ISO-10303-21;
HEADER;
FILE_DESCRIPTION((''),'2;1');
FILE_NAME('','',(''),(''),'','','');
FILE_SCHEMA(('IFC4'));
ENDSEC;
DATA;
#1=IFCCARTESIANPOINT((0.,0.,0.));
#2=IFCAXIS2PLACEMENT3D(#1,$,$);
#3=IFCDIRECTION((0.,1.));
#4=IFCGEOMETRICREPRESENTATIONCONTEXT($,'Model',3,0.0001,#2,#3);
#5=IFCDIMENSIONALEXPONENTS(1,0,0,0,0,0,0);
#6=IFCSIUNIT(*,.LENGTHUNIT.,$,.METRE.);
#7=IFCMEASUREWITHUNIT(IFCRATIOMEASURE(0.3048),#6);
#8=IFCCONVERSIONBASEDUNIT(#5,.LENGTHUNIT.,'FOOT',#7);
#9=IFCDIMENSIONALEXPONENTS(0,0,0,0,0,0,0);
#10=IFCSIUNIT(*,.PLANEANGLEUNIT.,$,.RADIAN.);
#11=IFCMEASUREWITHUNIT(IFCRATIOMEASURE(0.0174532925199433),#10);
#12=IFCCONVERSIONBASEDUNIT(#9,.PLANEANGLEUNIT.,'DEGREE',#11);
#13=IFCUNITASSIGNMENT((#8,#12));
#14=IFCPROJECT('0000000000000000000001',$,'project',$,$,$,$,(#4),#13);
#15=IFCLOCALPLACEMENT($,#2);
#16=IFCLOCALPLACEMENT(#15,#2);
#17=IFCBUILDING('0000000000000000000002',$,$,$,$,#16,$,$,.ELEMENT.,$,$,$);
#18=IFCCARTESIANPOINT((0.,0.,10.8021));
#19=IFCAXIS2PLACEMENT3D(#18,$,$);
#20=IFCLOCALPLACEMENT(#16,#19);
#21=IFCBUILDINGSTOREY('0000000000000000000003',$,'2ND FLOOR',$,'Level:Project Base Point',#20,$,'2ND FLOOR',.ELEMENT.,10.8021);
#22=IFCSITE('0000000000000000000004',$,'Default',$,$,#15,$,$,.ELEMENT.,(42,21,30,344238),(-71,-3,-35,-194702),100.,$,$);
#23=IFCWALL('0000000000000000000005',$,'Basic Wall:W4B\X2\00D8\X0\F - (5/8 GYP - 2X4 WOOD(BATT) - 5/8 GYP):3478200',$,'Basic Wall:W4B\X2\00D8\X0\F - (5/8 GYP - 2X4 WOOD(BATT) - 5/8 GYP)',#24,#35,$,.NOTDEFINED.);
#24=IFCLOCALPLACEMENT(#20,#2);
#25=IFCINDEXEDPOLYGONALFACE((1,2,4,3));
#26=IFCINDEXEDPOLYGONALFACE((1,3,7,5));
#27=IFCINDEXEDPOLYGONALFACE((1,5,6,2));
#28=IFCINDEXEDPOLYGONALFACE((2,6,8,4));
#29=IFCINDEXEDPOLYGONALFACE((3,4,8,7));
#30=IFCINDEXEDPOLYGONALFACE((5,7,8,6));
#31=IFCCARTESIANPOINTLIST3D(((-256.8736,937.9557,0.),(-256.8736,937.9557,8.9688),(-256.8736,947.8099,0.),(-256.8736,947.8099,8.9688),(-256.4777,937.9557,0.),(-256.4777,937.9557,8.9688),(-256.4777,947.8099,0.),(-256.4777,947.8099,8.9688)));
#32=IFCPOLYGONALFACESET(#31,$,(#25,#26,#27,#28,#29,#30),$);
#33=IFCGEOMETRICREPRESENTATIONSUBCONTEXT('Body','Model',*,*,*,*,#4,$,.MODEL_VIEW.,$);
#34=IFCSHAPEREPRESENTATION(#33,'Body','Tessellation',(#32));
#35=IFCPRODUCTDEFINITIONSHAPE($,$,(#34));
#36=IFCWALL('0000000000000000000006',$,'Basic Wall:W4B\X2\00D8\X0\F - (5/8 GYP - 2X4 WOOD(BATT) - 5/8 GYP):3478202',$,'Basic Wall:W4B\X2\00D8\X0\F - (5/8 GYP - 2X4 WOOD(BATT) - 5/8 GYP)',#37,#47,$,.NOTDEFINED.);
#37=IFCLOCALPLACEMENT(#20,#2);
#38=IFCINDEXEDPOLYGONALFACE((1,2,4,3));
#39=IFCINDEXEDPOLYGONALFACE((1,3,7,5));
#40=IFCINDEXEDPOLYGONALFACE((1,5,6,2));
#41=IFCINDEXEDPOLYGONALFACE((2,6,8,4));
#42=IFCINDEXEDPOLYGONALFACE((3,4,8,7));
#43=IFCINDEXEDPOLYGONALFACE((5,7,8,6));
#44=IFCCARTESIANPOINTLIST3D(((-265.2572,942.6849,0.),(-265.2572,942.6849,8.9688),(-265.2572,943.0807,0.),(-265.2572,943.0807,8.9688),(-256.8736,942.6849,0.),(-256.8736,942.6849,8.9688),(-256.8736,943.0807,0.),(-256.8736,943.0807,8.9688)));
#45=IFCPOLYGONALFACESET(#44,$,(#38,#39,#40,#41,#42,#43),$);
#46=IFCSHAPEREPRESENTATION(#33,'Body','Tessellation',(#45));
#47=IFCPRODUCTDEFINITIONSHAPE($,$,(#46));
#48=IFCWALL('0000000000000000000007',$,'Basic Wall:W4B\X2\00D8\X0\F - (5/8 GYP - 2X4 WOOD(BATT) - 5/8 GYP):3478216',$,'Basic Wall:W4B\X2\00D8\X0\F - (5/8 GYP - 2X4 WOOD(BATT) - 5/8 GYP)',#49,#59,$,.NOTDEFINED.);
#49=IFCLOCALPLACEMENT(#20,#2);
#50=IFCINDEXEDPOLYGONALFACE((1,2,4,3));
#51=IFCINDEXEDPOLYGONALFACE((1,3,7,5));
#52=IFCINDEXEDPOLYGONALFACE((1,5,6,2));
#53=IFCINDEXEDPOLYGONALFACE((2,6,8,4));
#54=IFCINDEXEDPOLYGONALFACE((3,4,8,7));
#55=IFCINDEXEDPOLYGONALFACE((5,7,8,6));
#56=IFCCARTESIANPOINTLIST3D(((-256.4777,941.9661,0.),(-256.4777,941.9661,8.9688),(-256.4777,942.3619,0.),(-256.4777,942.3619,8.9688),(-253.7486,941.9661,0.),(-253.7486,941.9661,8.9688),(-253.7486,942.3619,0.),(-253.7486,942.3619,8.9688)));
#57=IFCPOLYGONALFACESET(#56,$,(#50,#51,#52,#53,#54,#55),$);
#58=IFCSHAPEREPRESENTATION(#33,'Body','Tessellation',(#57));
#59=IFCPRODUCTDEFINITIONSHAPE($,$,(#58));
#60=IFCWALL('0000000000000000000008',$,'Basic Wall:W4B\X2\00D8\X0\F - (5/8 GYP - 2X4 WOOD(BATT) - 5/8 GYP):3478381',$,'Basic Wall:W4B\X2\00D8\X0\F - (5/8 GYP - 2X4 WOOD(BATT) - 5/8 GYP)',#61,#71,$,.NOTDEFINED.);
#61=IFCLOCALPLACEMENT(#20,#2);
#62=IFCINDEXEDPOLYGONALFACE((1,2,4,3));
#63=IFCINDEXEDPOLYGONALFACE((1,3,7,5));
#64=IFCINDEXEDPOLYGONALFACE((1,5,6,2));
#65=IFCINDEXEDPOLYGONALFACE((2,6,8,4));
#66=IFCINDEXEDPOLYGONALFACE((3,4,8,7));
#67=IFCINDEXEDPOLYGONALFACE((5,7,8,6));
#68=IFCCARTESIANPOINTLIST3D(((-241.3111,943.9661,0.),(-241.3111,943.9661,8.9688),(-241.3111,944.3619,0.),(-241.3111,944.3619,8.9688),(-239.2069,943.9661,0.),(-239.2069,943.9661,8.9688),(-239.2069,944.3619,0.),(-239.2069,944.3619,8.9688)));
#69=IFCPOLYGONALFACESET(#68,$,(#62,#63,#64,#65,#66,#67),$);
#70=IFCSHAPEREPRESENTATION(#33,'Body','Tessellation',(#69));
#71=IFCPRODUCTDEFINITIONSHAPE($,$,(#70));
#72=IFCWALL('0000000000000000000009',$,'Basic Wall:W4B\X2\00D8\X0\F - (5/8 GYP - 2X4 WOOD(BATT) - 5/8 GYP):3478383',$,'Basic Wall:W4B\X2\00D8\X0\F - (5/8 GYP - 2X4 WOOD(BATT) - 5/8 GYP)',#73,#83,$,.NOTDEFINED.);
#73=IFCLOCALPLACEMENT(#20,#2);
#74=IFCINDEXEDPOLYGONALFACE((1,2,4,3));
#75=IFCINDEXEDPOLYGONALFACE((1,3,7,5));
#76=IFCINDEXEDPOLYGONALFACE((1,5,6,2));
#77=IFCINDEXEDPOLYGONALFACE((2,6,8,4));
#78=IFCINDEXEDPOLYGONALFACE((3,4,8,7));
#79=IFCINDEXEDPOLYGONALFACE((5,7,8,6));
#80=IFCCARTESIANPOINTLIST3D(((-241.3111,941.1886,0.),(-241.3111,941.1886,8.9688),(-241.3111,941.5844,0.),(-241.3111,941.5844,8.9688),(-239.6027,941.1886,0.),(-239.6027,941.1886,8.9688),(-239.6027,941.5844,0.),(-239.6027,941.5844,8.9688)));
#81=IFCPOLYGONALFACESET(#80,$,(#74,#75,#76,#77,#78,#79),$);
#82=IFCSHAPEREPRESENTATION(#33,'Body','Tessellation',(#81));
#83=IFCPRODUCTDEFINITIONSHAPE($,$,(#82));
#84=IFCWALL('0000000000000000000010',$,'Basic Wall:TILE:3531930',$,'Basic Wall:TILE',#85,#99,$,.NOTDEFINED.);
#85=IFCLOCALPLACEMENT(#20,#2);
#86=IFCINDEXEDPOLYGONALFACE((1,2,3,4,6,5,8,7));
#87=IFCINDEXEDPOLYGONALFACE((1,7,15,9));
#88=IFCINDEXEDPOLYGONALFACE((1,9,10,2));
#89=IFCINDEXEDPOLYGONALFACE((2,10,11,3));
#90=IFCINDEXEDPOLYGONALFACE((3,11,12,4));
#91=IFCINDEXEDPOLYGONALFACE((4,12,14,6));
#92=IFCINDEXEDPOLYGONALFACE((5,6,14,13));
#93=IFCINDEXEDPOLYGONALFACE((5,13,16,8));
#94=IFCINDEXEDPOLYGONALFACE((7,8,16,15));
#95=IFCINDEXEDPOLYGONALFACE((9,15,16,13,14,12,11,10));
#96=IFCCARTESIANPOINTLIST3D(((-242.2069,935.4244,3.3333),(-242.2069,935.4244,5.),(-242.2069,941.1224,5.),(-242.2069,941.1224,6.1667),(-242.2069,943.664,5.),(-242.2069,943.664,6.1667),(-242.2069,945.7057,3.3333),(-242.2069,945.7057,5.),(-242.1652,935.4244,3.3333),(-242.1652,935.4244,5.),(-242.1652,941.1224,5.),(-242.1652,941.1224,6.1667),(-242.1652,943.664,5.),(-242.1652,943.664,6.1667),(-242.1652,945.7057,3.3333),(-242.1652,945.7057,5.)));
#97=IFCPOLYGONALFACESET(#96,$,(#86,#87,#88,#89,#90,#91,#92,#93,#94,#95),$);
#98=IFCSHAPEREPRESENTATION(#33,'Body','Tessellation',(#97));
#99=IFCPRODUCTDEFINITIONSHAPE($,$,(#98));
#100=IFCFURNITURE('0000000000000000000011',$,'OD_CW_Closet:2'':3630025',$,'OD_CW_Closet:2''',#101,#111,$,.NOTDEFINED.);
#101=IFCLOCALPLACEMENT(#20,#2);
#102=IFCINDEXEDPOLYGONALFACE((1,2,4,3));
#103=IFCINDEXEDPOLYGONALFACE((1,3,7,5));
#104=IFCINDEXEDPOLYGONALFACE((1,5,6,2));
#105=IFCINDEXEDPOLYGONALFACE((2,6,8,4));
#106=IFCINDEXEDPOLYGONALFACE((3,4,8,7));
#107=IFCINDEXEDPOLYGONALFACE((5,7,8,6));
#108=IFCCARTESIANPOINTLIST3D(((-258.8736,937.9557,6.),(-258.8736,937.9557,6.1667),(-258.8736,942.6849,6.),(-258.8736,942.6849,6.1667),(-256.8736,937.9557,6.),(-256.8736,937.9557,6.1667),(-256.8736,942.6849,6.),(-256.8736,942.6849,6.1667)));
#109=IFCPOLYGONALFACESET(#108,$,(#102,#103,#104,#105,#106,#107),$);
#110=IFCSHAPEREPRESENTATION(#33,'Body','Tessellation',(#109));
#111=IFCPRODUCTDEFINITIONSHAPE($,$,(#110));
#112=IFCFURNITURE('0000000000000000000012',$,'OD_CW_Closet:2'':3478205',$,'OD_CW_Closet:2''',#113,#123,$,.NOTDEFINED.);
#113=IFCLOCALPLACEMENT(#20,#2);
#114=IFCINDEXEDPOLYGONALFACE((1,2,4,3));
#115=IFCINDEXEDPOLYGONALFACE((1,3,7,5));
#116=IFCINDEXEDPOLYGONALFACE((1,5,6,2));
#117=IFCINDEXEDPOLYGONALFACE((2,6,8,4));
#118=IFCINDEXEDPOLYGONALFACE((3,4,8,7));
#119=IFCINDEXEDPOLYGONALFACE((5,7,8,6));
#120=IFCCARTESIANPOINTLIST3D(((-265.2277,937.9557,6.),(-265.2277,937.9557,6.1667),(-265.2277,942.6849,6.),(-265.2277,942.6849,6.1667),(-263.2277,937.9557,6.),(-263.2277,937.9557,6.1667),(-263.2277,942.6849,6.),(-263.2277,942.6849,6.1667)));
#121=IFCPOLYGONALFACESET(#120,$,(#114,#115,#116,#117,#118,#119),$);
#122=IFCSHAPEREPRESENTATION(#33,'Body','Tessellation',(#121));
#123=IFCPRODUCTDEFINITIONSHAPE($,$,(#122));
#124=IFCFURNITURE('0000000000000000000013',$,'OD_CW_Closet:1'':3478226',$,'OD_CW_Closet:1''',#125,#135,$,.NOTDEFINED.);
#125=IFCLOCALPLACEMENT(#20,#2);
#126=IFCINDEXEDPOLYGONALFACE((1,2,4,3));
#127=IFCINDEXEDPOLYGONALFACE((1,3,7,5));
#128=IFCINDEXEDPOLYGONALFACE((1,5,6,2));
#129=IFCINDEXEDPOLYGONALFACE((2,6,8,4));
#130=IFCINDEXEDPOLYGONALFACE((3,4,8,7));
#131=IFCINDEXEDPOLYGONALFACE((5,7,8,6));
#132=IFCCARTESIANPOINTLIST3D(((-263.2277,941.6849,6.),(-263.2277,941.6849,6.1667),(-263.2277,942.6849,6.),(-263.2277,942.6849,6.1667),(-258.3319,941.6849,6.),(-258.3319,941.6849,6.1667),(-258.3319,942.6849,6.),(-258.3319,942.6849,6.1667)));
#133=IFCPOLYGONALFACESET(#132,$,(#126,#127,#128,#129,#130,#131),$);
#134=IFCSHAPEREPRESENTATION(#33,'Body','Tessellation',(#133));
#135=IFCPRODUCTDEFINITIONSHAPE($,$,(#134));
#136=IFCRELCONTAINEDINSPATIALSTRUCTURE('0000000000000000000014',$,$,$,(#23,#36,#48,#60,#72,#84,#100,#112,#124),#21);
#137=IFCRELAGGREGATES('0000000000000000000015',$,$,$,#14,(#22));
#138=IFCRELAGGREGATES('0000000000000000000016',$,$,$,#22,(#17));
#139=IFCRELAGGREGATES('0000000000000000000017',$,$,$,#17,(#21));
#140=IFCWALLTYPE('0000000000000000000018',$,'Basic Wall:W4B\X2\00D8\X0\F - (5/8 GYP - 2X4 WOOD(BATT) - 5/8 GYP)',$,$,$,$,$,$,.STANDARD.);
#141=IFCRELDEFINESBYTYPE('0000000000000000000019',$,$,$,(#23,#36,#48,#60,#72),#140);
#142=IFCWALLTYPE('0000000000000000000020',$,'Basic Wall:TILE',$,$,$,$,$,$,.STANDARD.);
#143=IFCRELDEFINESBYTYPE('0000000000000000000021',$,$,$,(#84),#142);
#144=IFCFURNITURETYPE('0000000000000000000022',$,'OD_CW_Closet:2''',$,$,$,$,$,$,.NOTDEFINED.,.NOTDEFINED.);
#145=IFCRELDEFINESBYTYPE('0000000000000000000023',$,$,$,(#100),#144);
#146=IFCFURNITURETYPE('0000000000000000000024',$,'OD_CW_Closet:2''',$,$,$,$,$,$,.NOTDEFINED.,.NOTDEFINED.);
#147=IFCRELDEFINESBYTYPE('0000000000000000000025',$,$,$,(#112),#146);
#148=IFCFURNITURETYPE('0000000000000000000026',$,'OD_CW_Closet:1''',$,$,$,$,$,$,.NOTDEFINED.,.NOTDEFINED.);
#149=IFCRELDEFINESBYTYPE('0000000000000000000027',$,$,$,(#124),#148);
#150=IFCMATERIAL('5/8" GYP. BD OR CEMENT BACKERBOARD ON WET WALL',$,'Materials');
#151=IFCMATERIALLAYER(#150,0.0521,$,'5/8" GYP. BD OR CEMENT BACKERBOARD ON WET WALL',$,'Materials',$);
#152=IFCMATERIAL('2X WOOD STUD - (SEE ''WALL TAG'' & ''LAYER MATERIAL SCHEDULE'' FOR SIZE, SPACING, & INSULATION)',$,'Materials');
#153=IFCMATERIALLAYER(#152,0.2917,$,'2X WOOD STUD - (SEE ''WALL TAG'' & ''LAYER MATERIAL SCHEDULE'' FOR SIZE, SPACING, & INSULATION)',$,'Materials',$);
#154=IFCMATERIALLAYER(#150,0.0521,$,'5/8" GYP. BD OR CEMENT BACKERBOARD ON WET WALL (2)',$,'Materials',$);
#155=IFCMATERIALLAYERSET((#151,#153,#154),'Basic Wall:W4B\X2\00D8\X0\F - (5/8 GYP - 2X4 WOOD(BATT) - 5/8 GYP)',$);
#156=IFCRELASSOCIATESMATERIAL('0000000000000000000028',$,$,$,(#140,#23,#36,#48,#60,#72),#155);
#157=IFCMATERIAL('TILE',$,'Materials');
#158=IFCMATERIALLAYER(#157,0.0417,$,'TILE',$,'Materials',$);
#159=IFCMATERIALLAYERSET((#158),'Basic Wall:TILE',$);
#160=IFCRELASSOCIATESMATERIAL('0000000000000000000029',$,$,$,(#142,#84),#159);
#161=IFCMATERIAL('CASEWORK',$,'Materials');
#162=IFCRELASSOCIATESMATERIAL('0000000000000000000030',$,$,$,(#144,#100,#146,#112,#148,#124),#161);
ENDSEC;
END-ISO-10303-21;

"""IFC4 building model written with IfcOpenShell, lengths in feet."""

from ifc_helpers import new_model, entity, si_unit, converted_unit, direction, frame, frame_2d, origin, origin_2d_with_axis, place, context, subcontext, project, spatial, rectangle, extrude, source, transform, mapped, material, layer, layer_set, layer_usage, type_object, type_shapes, element, save


model = new_model("IFC4")

# Units and contexts
model_context = context("Model", 3, precision=0.0001, world=origin(), true_north=direction((0.0, 1.0)))
body_context = subcontext(model_context, "Body", "Model", "MODEL_VIEW")
ifc_project = project(units=[converted_unit("LENGTHUNIT", "FOOT", entity("IfcRatioMeasure", 0.3048), si_unit("LENGTHUNIT", "METRE"), dimensions=[1, 0, 0, 0, 0, 0, 0]), converted_unit("PLANEANGLEUNIT", "DEGREE", entity("IfcRatioMeasure", 0.0174532925199433), si_unit("PLANEANGLEUNIT", "RADIAN"), dimensions=[0, 0, 0, 0, 0, 0, 0])], contexts=[model_context])

# Site, building, storey
site_placement = place(None, origin())
site = spatial("IfcSite", under=ifc_project, at=site_placement, Name="Default", CompositionType="ELEMENT", RefLatitude=(42, 21, 30, 344238), RefLongitude=(-71, -3, -35, -194702), RefElevation=100.0)
building_placement = place(site_placement, origin())
building = spatial("IfcBuilding", under=site, at=building_placement, CompositionType="ELEMENT")
storey_placement = place(building_placement, frame((0.0, 0.0, 10.8021)))
storey = spatial("IfcBuildingStorey", under=building, at=storey_placement, Name="2ND FLOOR", ObjectType="Level:Project Base Point", LongName="2ND FLOOR", CompositionType="ELEMENT", Elevation=10.8021)

# Shared definitions
ifc_material_1 = material(Name="5/8\" GYP. BD OR CEMENT BACKERBOARD ON WET WALL", Category="Materials")
ifc_layer_1 = layer(ifc_material_1, 0.0521, Name="5/8\" GYP. BD OR CEMENT BACKERBOARD ON WET WALL", Category="Materials")
ifc_material_2 = material(Name="2X WOOD STUD - (SEE 'WALL TAG' & 'LAYER MATERIAL SCHEDULE' FOR SIZE, SPACING, & INSULATION)", Category="Materials")
ifc_layer_2 = layer(ifc_material_2, 0.2917, Name="2X WOOD STUD - (SEE 'WALL TAG' & 'LAYER MATERIAL SCHEDULE' FOR SIZE, SPACING, & INSULATION)", Category="Materials")
ifc_layer_3 = layer(ifc_material_1, 0.0521, Name="5/8\" GYP. BD OR CEMENT BACKERBOARD ON WET WALL (2)", Category="Materials")
ifc_layer_set_1 = layer_set([ifc_layer_1, ifc_layer_2, ifc_layer_3], Name="Basic Wall:W4BØF - (5/8 GYP - 2X4 WOOD(BATT) - 5/8 GYP)")
wall_type_1 = type_object("IfcWallType", Name="Basic Wall:W4BØF - (5/8 GYP - 2X4 WOOD(BATT) - 5/8 GYP)", PredefinedType="STANDARD", material=ifc_layer_set_1)

# Walls
ifc_layer_usage_1 = layer_usage(ifc_layer_set_1, "AXIS2", "NEGATIVE", 0.1979)
wall_1_placement = place(storey_placement, frame((-256.6757, 937.9557, 0.0), z_axis=(0.0, 0.0, 1.0), x_axis=(0.0, 1.0, 0.0)))
element("IfcWall", 1, at=wall_1_placement, inside=storey, type_object=wall_type_1, material=ifc_layer_usage_1, Name="Basic Wall:W4BØF - (5/8 GYP - 2X4 WOOD(BATT) - 5/8 GYP):3478200", ObjectType="Basic Wall:W4BØF - (5/8 GYP - 2X4 WOOD(BATT) - 5/8 GYP)", PredefinedType="NOTDEFINED", context=body_context, shape_type="SweptSolid", body=[
    extrude(rectangle(XDim=9.8542, YDim=0.3958, at=frame_2d((4.9271, 0.0), x_axis=(-1.0, 0.0))), origin(), (0.0, 0.0, 1.0), 8.9688),
])
ifc_layer_usage_2 = layer_usage(ifc_layer_set_1, "AXIS2", "POSITIVE", -0.1979)
wall_2_placement = place(storey_placement, frame((-256.8736, 942.8828, 0.0), z_axis=(0.0, 0.0, 1.0), x_axis=(-1.0, 0.0, 0.0)))
element("IfcWall", 2, at=wall_2_placement, inside=storey, type_object=wall_type_1, material=ifc_layer_usage_2, Name="Basic Wall:W4BØF - (5/8 GYP - 2X4 WOOD(BATT) - 5/8 GYP):3478202", ObjectType="Basic Wall:W4BØF - (5/8 GYP - 2X4 WOOD(BATT) - 5/8 GYP)", PredefinedType="NOTDEFINED", context=body_context, shape_type="SweptSolid", body=[
    extrude(rectangle(XDim=8.3836, YDim=0.3958, at=frame_2d((4.1918, 0.0), x_axis=(-1.0, 0.0))), origin(), (0.0, 0.0, 1.0), 8.9688),
])
ifc_layer_usage_3 = layer_usage(ifc_layer_set_1, "AXIS2", "NEGATIVE", 0.1979)
wall_3_placement = place(storey_placement, frame((-256.4777, 942.164, 0.0)))
element("IfcWall", 3, at=wall_3_placement, inside=storey, type_object=wall_type_1, material=ifc_layer_usage_3, Name="Basic Wall:W4BØF - (5/8 GYP - 2X4 WOOD(BATT) - 5/8 GYP):3478216", ObjectType="Basic Wall:W4BØF - (5/8 GYP - 2X4 WOOD(BATT) - 5/8 GYP)", PredefinedType="NOTDEFINED", context=body_context, shape_type="SweptSolid", body=[
    extrude(rectangle(XDim=2.7292, YDim=0.3958, at=frame_2d((1.3646, 0.0), x_axis=(-1.0, 0.0))), origin(), (0.0, 0.0, 1.0), 8.9688),
])
ifc_layer_usage_4 = layer_usage(ifc_layer_set_1, "AXIS2", "NEGATIVE", 0.1979)
wall_4_placement = place(storey_placement, frame((-241.3111, 944.164, 0.0)))
element("IfcWall", 4, at=wall_4_placement, inside=storey, type_object=wall_type_1, material=ifc_layer_usage_4, Name="Basic Wall:W4BØF - (5/8 GYP - 2X4 WOOD(BATT) - 5/8 GYP):3478381", ObjectType="Basic Wall:W4BØF - (5/8 GYP - 2X4 WOOD(BATT) - 5/8 GYP)", PredefinedType="NOTDEFINED", context=body_context, shape_type="SweptSolid", body=[
    extrude(rectangle(XDim=2.1042, YDim=0.3958, at=frame_2d((1.0521, 0.0), x_axis=(-1.0, 0.0))), origin(), (0.0, 0.0, 1.0), 8.9688),
])

# Wall
ifc_layer_usage_5 = layer_usage(ifc_layer_set_1, "AXIS2", "NEGATIVE", 0.1979)
wall_5_placement = place(storey_placement, frame((-239.6027, 941.3865, 0.0), z_axis=(0.0, 0.0, 1.0), x_axis=(-1.0, 0.0, 0.0)))
element("IfcWall", 5, at=wall_5_placement, inside=storey, type_object=wall_type_1, material=ifc_layer_usage_5, Name="Basic Wall:W4BØF - (5/8 GYP - 2X4 WOOD(BATT) - 5/8 GYP):3478383", ObjectType="Basic Wall:W4BØF - (5/8 GYP - 2X4 WOOD(BATT) - 5/8 GYP)", PredefinedType="NOTDEFINED", context=body_context, shape_type="SweptSolid", body=[
    extrude(rectangle(XDim=1.7083, YDim=0.3958, at=frame_2d((0.8542, 0.0), x_axis=(-1.0, 0.0))), origin(), (0.0, 0.0, 1.0), 8.9688),
])

# Wall, openings
ifc_material_3 = material(Name="TILE", Category="Materials")
ifc_layer_4 = layer(ifc_material_3, 0.0417, Name="TILE", Category="Materials")
ifc_layer_set_2 = layer_set([ifc_layer_4], Name="Basic Wall:TILE")
ifc_layer_usage_6 = layer_usage(ifc_layer_set_2, "AXIS2", "NEGATIVE", 0.0208)
wall_type_2 = type_object("IfcWallType", Name="Basic Wall:TILE", PredefinedType="STANDARD", material=ifc_layer_set_2)
wall_6_placement = place(storey_placement, frame((-242.1861, 945.7057, 3.3333), z_axis=(0.0, 0.0, 1.0), x_axis=(0.0, -1.0, 0.0)))
wall_6 = element("IfcWall", 6, at=wall_6_placement, inside=storey, type_object=wall_type_2, material=ifc_layer_usage_6, Name="Basic Wall:TILE:3531930", ObjectType="Basic Wall:TILE", PredefinedType="NOTDEFINED", context=body_context, shape_type="SweptSolid", body=[
    extrude(rectangle(XDim=10.2813, YDim=0.0417, at=frame_2d((5.1406, 0.0), x_axis=(-1.0, 0.0))), origin(), (0.0, 0.0, 1.0), 2.8333),
])
opening_1_placement = place(wall_6_placement, origin())
element("IfcOpeningElement", 7, at=opening_1_placement, cuts=wall_6, PredefinedType="OPENING", context=body_context, shape_type="SweptSolid", body=[
    extrude(rectangle(XDim=1.1667, YDim=5.6979, at=origin_2d_with_axis()), frame((7.4323, 0.0208, 2.25), z_axis=(0.0, -1.0, 0.0), x_axis=(0.0, 0.0, 1.0)), (0.0, 0.0, 1.0), 0.0417),
])
opening_2_placement = place(wall_6_placement, origin())
element("IfcOpeningElement", 8, at=opening_2_placement, cuts=wall_6, PredefinedType="OPENING", context=body_context, shape_type="SweptSolid", body=[
    extrude(rectangle(XDim=1.1667, YDim=2.0417, at=frame_2d((0.0, 0.0), x_axis=(0.0, 1.0))), frame((1.0208, 0.0208, 2.25), z_axis=(0.0, -1.0, 0.0), x_axis=(-1.0, 0.0, 0.0)), (0.0, 0.0, 1.0), 0.0417),
])

# Furniture
ifc_material_4 = material(Name="CASEWORK", Category="Materials")
furniture_type_1 = type_object("IfcFurnitureType", Name="OD_CW_Closet:2'", AssemblyPlace="NOTDEFINED", PredefinedType="NOTDEFINED", material=ifc_material_4)
shared_shape_1 = source(origin(), body_context, "Body", "SweptSolid", [
    extrude(rectangle(XDim=4.7292, YDim=2.0, at=origin_2d_with_axis()), frame((2.3646, 1.0, 0.0)), (0.0, 0.0, 1.0), 0.1667),
])
type_shapes(furniture_type_1, [shared_shape_1])
furniture_1_placement = place(storey_placement, frame((-256.8736, 937.9557, 6.0), z_axis=(0.0, 0.0, 1.0), x_axis=(0.0, 1.0, 0.0)))
element("IfcFurniture", 9, at=furniture_1_placement, inside=storey, type_object=furniture_type_1, material=ifc_material_4, Name="OD_CW_Closet:2':3630025", ObjectType="OD_CW_Closet:2'", PredefinedType="NOTDEFINED", context=body_context, shape_type="MappedRepresentation", body=[
    mapped(shared_shape_1, transform((0.0, 0.0, 0.0), scale=1.0)),
])
furniture_type_2 = type_object("IfcFurnitureType", Name="OD_CW_Closet:2'", AssemblyPlace="NOTDEFINED", PredefinedType="NOTDEFINED", material=ifc_material_4)
shared_shape_2 = source(origin(), body_context, "Body", "SweptSolid", [
    extrude(rectangle(XDim=2.0, YDim=4.7292, at=origin_2d_with_axis()), frame((2.3646, 1.0, 0.0), z_axis=(0.0, 0.0, 1.0), x_axis=(0.0, -1.0, 0.0)), (0.0, 0.0, 1.0), 0.1667),
])
type_shapes(furniture_type_2, [shared_shape_2])
furniture_2_placement = place(storey_placement, frame((-263.2277, 937.9557, 6.0), z_axis=(0.0, 0.0, 1.0), x_axis=(0.0, 1.0, 0.0)))
element("IfcFurniture", 10, at=furniture_2_placement, inside=storey, type_object=furniture_type_2, material=ifc_material_4, Name="OD_CW_Closet:2':3478205", ObjectType="OD_CW_Closet:2'", PredefinedType="NOTDEFINED", context=body_context, shape_type="MappedRepresentation", body=[
    mapped(shared_shape_2, transform((0.0, 0.0, 0.0), scale=1.0)),
])
furniture_type_3 = type_object("IfcFurnitureType", Name="OD_CW_Closet:1'", AssemblyPlace="NOTDEFINED", PredefinedType="NOTDEFINED", material=ifc_material_4)
shared_shape_3 = source(origin(), body_context, "Body", "SweptSolid", [
    extrude(rectangle(XDim=1.0, YDim=4.8958, at=frame_2d((0.0, 0.0), x_axis=(1.0, 0.0))), frame((2.4479, 0.5, 0.0), z_axis=(0.0, 0.0, 1.0), x_axis=(0.0, -1.0, 0.0)), (0.0, 0.0, 1.0), 0.1667),
])
type_shapes(furniture_type_3, [shared_shape_3])
furniture_3_placement = place(storey_placement, frame((-263.2277, 941.6849, 6.0)))
element("IfcFurniture", 11, at=furniture_3_placement, inside=storey, type_object=furniture_type_3, material=ifc_material_4, Name="OD_CW_Closet:1':3478226", ObjectType="OD_CW_Closet:1'", PredefinedType="NOTDEFINED", context=body_context, shape_type="MappedRepresentation", body=[
    mapped(shared_shape_3, transform((0.0, 0.0, 0.0), scale=1.0)),
])

save(model, "model.ifc")
